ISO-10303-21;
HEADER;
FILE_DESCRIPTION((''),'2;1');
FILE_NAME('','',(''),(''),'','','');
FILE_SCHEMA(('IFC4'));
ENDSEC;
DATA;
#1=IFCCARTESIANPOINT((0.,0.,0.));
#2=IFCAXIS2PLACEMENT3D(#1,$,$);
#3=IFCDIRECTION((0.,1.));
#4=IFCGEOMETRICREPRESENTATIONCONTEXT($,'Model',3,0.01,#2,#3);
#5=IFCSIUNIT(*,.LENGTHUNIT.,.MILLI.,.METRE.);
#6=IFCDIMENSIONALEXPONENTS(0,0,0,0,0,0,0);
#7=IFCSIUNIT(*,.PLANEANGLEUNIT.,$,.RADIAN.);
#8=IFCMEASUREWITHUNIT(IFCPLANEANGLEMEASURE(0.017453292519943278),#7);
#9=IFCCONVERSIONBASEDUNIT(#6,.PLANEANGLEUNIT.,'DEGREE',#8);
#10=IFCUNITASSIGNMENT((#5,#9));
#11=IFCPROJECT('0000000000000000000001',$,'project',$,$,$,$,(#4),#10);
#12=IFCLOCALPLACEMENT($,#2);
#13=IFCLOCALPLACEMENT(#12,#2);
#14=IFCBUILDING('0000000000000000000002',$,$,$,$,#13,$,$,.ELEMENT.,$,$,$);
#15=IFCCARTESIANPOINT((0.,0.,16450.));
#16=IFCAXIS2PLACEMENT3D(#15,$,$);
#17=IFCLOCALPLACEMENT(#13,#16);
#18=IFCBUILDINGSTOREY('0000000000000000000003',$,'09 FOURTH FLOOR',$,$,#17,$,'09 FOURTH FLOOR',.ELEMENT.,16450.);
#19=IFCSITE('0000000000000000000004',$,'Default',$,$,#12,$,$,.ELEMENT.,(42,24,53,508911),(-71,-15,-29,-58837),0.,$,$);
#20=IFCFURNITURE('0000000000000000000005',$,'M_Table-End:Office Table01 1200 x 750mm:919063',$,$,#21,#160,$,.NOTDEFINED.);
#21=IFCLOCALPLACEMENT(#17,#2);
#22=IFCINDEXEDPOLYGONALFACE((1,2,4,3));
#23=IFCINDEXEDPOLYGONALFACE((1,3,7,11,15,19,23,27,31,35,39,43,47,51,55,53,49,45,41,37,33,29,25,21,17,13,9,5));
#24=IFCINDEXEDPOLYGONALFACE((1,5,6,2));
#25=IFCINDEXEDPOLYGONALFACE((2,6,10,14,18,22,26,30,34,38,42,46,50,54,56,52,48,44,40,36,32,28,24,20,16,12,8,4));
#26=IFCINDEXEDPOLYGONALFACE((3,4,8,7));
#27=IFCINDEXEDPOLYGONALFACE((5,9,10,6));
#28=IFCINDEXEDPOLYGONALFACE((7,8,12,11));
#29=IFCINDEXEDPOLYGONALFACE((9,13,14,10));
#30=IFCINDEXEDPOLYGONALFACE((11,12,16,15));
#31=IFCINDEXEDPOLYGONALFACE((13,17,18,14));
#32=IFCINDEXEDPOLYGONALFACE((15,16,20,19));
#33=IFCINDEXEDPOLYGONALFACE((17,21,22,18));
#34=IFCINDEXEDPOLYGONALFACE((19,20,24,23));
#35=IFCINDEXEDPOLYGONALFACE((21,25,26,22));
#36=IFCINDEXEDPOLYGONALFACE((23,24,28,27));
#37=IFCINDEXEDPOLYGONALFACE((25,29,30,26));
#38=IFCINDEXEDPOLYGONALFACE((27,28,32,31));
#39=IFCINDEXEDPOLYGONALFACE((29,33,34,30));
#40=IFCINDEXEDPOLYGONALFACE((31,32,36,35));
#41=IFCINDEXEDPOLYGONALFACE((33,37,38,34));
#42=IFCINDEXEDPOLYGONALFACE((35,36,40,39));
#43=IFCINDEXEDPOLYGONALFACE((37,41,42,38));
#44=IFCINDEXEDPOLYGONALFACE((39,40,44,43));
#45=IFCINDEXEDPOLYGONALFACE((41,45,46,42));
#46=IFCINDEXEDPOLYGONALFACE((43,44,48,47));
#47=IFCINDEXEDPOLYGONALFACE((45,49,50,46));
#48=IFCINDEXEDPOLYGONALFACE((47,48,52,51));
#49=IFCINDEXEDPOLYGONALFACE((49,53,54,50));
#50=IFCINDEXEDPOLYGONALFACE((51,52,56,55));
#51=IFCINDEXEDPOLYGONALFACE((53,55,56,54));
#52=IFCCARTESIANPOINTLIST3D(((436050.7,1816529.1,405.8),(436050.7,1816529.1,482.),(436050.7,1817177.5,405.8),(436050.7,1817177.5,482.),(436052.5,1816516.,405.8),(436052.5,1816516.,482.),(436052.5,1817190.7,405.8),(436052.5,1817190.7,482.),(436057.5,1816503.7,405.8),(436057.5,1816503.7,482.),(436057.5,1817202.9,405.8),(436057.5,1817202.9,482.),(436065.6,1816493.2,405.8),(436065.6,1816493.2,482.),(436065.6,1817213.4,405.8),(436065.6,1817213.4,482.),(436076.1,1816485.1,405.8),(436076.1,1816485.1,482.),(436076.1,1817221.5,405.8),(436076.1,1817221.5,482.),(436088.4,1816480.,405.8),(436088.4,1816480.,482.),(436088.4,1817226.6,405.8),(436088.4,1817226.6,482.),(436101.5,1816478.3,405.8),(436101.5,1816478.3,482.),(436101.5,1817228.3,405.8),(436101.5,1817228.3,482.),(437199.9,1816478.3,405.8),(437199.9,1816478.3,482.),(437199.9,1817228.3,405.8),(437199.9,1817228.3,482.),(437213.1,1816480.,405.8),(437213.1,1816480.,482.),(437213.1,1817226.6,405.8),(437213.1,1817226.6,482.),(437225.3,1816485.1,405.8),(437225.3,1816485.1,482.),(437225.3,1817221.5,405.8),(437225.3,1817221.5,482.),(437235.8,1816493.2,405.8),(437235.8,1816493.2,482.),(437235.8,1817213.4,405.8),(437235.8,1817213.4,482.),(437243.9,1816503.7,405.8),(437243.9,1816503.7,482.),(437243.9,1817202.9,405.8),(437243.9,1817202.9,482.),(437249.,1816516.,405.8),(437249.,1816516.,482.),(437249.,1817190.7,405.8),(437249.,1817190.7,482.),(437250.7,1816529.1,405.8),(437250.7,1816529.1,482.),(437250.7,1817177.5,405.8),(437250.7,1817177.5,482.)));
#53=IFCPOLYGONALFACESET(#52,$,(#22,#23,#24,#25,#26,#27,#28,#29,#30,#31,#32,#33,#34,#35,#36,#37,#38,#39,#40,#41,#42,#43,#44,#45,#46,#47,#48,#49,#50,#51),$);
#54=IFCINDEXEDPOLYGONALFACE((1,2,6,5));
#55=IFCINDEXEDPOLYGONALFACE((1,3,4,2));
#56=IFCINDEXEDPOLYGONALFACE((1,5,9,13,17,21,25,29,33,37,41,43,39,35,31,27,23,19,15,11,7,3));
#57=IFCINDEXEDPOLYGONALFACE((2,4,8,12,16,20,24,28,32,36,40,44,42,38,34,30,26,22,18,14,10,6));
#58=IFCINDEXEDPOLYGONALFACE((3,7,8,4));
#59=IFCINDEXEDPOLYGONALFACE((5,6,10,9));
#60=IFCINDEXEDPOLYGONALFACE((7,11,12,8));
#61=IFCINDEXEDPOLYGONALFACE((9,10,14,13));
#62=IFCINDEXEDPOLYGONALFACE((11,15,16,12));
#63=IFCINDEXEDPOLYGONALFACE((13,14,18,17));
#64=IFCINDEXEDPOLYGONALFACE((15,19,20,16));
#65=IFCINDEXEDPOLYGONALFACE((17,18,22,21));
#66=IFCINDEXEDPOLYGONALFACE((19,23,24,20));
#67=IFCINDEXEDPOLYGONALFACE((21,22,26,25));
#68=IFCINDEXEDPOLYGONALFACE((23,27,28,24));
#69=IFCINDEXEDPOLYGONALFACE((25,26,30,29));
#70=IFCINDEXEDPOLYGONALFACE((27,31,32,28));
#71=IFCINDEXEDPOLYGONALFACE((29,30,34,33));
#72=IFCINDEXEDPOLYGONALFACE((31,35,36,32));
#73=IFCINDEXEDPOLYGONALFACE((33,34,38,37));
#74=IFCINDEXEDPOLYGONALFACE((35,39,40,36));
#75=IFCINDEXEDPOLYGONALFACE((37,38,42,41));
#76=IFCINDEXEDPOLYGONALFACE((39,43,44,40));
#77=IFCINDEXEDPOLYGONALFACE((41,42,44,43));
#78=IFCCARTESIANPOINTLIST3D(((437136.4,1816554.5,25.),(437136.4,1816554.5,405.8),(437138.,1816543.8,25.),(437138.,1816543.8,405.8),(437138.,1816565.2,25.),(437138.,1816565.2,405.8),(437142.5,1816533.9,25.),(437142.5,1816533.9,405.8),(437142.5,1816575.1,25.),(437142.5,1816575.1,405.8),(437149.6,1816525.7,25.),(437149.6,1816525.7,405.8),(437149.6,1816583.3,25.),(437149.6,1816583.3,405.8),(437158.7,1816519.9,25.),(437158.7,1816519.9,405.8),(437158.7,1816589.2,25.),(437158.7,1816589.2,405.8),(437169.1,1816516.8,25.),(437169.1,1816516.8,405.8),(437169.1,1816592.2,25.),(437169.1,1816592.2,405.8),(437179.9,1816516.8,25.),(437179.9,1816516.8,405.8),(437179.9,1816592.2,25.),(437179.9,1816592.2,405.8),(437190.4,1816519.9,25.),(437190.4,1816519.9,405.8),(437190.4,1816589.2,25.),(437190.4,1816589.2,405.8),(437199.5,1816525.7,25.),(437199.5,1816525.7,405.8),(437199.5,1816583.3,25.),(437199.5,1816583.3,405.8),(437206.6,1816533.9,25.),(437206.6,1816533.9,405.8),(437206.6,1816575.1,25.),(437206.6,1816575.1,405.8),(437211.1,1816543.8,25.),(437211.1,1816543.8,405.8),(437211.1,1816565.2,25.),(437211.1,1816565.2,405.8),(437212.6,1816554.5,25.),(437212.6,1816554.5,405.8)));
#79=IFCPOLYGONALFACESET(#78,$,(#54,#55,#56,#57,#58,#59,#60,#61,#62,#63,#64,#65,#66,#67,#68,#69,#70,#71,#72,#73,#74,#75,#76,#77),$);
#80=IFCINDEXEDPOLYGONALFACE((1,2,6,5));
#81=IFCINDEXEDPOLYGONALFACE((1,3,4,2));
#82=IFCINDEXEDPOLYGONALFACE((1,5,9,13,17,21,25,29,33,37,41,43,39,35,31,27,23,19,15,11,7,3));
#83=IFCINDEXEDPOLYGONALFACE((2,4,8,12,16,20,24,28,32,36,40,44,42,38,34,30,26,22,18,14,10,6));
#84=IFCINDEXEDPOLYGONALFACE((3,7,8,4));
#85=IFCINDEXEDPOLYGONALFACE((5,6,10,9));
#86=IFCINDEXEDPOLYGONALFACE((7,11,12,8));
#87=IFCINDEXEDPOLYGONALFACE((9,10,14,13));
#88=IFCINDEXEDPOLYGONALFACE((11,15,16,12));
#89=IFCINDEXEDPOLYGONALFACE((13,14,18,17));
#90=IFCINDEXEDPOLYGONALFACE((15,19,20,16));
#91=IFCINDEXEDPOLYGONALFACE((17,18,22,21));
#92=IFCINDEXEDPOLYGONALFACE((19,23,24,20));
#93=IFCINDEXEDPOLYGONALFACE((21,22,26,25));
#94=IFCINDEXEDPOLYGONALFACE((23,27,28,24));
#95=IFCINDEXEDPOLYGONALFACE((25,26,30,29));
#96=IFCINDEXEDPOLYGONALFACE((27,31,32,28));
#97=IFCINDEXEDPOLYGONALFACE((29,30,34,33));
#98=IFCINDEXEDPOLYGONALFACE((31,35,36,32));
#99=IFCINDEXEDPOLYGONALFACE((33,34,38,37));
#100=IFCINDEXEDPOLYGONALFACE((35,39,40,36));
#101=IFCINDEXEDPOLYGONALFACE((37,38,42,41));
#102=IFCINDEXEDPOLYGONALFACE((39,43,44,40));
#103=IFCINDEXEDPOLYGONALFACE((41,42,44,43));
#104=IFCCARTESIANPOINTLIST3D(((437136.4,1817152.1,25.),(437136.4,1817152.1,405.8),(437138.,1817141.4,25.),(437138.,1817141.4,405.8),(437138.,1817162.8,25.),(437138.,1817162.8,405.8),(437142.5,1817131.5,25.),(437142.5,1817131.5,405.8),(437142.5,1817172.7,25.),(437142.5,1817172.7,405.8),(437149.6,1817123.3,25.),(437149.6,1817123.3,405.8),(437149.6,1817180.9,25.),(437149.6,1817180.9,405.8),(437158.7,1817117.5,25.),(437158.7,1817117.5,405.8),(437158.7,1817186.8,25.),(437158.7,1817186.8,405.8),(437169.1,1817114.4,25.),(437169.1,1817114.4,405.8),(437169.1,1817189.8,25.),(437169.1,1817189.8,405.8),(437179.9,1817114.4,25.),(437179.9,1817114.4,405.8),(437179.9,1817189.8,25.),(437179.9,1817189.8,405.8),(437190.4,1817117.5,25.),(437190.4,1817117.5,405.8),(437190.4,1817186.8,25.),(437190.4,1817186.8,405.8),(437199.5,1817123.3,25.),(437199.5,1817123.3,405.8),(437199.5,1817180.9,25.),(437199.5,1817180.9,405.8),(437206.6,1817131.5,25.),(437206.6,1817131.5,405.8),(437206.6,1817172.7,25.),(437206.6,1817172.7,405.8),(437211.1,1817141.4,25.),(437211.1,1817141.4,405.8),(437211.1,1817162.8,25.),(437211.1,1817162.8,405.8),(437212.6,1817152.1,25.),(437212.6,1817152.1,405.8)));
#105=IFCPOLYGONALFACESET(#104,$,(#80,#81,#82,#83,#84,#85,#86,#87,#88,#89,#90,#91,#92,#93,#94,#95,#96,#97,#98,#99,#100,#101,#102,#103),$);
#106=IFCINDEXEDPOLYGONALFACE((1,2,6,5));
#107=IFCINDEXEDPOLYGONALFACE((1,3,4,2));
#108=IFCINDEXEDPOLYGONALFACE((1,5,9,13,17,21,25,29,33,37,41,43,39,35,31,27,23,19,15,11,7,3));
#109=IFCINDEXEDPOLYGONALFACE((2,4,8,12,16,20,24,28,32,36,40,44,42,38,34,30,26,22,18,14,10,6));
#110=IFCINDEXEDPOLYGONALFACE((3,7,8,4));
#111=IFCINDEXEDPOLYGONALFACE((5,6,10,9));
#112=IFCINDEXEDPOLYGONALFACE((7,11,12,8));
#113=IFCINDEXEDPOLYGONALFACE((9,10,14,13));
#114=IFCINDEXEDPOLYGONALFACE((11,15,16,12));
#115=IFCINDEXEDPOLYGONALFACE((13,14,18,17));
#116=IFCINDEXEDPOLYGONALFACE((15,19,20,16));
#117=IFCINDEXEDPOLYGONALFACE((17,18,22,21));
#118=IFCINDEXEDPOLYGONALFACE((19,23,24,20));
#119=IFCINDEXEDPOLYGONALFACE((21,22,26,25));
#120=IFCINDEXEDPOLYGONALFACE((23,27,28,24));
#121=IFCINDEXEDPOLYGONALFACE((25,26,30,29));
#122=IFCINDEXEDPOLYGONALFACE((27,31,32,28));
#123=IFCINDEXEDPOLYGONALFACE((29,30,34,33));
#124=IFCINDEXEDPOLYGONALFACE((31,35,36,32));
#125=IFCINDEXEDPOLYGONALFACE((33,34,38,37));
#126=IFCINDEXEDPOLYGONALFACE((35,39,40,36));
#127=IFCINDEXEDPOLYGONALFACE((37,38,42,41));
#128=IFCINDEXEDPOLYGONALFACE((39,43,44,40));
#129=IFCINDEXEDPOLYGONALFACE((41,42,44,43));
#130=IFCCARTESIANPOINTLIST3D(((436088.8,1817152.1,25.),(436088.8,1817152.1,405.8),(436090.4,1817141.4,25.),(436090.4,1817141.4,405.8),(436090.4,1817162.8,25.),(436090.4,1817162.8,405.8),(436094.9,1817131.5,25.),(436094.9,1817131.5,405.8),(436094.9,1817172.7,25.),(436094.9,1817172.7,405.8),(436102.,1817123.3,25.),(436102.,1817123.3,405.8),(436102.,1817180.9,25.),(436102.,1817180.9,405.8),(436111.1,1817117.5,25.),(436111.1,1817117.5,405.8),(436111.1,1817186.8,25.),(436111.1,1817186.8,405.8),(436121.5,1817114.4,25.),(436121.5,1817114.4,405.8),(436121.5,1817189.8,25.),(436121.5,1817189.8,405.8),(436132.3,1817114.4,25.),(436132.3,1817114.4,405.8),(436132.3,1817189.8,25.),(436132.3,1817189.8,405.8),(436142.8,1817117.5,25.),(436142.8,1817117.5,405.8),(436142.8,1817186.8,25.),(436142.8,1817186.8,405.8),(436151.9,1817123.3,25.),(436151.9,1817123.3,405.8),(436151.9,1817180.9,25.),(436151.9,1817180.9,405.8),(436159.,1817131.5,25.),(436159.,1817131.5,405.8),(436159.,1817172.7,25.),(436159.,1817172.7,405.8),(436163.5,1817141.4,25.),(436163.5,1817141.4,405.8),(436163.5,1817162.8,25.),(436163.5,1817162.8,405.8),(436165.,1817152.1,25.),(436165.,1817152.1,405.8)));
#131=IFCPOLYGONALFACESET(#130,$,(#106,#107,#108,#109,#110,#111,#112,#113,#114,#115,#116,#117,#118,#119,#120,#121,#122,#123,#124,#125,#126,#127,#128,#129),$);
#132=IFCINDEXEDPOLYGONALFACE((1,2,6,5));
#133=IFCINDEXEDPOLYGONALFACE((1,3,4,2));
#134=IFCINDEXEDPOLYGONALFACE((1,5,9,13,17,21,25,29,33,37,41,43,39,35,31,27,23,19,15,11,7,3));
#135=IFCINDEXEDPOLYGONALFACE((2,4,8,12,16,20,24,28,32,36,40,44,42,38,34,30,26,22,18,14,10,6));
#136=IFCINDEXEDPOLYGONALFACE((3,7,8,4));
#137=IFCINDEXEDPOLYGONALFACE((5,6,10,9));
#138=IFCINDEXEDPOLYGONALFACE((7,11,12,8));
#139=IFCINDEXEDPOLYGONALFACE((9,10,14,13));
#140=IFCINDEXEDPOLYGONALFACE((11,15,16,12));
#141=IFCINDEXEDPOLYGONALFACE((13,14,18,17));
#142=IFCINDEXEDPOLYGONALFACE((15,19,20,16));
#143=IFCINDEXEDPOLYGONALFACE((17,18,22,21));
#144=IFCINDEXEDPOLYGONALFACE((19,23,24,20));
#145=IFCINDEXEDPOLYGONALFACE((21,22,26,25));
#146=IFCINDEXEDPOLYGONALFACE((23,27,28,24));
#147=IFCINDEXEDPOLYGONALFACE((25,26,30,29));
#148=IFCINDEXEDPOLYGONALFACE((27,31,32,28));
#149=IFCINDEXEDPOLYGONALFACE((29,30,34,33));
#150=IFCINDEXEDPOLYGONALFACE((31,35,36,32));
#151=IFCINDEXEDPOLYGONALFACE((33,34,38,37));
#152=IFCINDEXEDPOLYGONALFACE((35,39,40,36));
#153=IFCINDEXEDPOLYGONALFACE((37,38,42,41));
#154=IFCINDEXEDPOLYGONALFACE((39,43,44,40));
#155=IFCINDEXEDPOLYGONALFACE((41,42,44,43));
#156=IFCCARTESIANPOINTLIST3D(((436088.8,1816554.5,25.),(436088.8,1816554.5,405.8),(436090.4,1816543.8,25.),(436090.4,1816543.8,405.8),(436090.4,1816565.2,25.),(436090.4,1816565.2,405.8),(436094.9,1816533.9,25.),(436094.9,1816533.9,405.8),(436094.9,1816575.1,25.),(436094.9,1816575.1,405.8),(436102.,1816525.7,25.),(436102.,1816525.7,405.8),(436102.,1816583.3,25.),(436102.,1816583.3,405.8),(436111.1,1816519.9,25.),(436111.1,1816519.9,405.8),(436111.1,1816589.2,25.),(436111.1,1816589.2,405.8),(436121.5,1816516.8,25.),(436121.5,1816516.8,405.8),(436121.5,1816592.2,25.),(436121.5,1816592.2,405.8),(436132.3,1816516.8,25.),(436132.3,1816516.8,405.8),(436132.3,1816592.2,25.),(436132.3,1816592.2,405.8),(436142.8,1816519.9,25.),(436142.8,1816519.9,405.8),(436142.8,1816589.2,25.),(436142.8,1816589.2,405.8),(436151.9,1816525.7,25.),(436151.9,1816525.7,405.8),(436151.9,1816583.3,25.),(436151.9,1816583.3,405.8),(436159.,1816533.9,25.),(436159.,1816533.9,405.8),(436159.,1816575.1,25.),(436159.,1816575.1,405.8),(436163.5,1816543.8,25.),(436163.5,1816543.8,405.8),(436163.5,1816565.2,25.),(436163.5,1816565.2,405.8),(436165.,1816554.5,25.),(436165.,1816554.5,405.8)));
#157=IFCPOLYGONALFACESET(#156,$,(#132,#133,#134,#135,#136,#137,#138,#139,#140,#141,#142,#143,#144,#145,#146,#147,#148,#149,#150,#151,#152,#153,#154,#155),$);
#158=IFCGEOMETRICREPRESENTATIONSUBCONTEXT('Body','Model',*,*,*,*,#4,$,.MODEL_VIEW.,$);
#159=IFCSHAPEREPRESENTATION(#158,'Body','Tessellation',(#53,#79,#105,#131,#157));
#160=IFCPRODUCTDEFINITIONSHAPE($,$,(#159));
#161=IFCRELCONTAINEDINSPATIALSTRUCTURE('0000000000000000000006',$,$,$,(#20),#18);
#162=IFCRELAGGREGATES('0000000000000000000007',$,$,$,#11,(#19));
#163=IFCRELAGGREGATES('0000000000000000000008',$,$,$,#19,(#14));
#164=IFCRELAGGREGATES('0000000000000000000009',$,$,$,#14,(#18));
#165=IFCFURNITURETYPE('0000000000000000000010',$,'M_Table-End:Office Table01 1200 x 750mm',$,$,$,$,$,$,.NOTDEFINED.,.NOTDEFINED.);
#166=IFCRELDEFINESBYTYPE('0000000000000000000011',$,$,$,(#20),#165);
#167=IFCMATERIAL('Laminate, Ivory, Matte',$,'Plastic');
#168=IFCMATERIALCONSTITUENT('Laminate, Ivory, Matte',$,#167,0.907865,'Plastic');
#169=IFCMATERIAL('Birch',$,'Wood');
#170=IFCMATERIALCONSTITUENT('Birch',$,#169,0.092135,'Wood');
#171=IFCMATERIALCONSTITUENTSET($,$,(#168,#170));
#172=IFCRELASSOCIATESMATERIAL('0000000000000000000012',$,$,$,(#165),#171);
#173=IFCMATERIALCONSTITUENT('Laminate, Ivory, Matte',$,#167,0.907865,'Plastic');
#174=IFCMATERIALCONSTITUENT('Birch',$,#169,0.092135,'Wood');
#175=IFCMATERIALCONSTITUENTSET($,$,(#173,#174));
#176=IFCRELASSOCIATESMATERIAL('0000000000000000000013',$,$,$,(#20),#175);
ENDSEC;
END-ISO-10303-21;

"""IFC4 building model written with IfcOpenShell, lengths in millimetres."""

from ifc_helpers import new_model, entity, si_unit, converted_unit, direction, frame, origin, place, context, subcontext, project, spatial, line, arc, indexed_curve, outline, extrude, source, transform, mapped, material, constituent, constituent_set, type_object, type_shapes, element, save


model = new_model("IFC4")

# Units and contexts
model_context = context("Model", 3, precision=0.01, world=origin(), true_north=direction((0.0, 1.0)))
body_context = subcontext(model_context, "Body", "Model", "MODEL_VIEW")
ifc_project = project(units=[si_unit("LENGTHUNIT", "METRE", prefix="MILLI"), converted_unit("PLANEANGLEUNIT", "DEGREE", entity("IfcPlaneAngleMeasure", 0.017453292519943278), si_unit("PLANEANGLEUNIT", "RADIAN"), dimensions=[0, 0, 0, 0, 0, 0, 0])], contexts=[model_context])

# Site, building, storey
site_placement = place(None, origin())
site = spatial("IfcSite", under=ifc_project, at=site_placement, Name="Default", CompositionType="ELEMENT", RefLatitude=(42, 24, 53, 508911), RefLongitude=(-71, -15, -29, -58837), RefElevation=0.0)
building_placement = place(site_placement, origin())
building = spatial("IfcBuilding", under=site, at=building_placement, CompositionType="ELEMENT")
storey_placement = place(building_placement, frame((0.0, 0.0, 16450.0)))
storey = spatial("IfcBuildingStorey", under=building, at=storey_placement, Name="09 FOURTH FLOOR", LongName="09 FOURTH FLOOR", CompositionType="ELEMENT", Elevation=16450.0)

# Furniture
ifc_material_1 = material(Name="Laminate, Ivory, Matte", Category="Plastic")
ifc_constituent_1 = constituent(ifc_material_1, Name="Laminate, Ivory, Matte", Category="Plastic", fraction=0.907865)
ifc_material_2 = material(Name="Birch", Category="Wood")
ifc_constituent_2 = constituent(ifc_material_2, Name="Birch", Category="Wood", fraction=0.092135)
ifc_constituent_set_1 = constituent_set(constituents=[ifc_constituent_1, ifc_constituent_2])
ifc_constituent_3 = constituent(ifc_material_1, Name="Laminate, Ivory, Matte", Category="Plastic", fraction=0.907865)
ifc_constituent_4 = constituent(ifc_material_2, Name="Birch", Category="Wood", fraction=0.092135)
ifc_constituent_set_2 = constituent_set(constituents=[ifc_constituent_3, ifc_constituent_4])
furniture_type_1 = type_object("IfcFurnitureType", Name="M_Table-End:Office Table01 1200 x 750mm", AssemblyPlace="NOTDEFINED", PredefinedType="NOTDEFINED", material=ifc_constituent_set_2)
shared_shape_1 = source(origin(), body_context, "Body", "SweptSolid", [
    extrude(outline(indexed_curve([(549.2, -375.0), (585.1, -360.1), (600.0, -324.2), (600.0, 324.2), (585.1, 360.1), (549.2, 375.0), (-549.2, 375.0), (-585.1, 360.1), (-600.0, 324.2), (-600.0, -324.2), (-585.1, -360.1), (-549.2, -375.0)], segments=[arc(1, 2, 3), line(3, 4), arc(4, 5, 6), line(6, 7), arc(7, 8, 9), line(9, 10), arc(10, 11, 12), line(12, 1)], self_intersect=False)), frame((603.7, 152.4, 405.8)), (0.0, 0.0, 1.0), 76.2),
    extrude(outline(indexed_curve([(-38.1, 0.0), (0.0, -38.1), (38.1, 0.0), (0.0, 38.1)], segments=[arc(1, 2, 3), arc(3, 4, 1)], self_intersect=False)), frame((1127.5, -146.4, 25.0)), (0.0, 0.0, 1.0), 380.8),
    extrude(outline(indexed_curve([(-38.1, 0.0), (0.0, -38.1), (38.1, 0.0), (0.0, 38.1)], segments=[arc(1, 2, 3), arc(3, 4, 1)], self_intersect=False)), frame((1127.5, 451.2, 25.0)), (0.0, 0.0, 1.0), 380.8),
    extrude(outline(indexed_curve([(-38.1, 0.0), (0.0, -38.1), (38.1, 0.0), (0.0, 38.1)], segments=[arc(1, 2, 3), arc(3, 4, 1)], self_intersect=False)), frame((79.9, 451.2, 25.0)), (0.0, 0.0, 1.0), 380.8),
    extrude(outline(indexed_curve([(-38.1, 0.0), (0.0, -38.1), (38.1, 0.0), (0.0, 38.1)], segments=[arc(1, 2, 3), arc(3, 4, 1)], self_intersect=False)), frame((79.9, -146.4, 25.0)), (0.0, 0.0, 1.0), 380.8),
])
type_shapes(furniture_type_1, [shared_shape_1])
furniture_1_placement = place(storey_placement, frame((436047.0, 1816700.9, 0.0)))
element("IfcFurniture", 1, at=furniture_1_placement, inside=storey, type_object=furniture_type_1, material=ifc_constituent_set_1, Name="M_Table-End:Office Table01 1200 x 750mm:919063", PredefinedType="NOTDEFINED", context=body_context, shape_type="MappedRepresentation", body=[
    mapped(shared_shape_1, transform((0.0, 0.0, 0.0), scale=1.0)),
])

save(model, "model.ifc")
